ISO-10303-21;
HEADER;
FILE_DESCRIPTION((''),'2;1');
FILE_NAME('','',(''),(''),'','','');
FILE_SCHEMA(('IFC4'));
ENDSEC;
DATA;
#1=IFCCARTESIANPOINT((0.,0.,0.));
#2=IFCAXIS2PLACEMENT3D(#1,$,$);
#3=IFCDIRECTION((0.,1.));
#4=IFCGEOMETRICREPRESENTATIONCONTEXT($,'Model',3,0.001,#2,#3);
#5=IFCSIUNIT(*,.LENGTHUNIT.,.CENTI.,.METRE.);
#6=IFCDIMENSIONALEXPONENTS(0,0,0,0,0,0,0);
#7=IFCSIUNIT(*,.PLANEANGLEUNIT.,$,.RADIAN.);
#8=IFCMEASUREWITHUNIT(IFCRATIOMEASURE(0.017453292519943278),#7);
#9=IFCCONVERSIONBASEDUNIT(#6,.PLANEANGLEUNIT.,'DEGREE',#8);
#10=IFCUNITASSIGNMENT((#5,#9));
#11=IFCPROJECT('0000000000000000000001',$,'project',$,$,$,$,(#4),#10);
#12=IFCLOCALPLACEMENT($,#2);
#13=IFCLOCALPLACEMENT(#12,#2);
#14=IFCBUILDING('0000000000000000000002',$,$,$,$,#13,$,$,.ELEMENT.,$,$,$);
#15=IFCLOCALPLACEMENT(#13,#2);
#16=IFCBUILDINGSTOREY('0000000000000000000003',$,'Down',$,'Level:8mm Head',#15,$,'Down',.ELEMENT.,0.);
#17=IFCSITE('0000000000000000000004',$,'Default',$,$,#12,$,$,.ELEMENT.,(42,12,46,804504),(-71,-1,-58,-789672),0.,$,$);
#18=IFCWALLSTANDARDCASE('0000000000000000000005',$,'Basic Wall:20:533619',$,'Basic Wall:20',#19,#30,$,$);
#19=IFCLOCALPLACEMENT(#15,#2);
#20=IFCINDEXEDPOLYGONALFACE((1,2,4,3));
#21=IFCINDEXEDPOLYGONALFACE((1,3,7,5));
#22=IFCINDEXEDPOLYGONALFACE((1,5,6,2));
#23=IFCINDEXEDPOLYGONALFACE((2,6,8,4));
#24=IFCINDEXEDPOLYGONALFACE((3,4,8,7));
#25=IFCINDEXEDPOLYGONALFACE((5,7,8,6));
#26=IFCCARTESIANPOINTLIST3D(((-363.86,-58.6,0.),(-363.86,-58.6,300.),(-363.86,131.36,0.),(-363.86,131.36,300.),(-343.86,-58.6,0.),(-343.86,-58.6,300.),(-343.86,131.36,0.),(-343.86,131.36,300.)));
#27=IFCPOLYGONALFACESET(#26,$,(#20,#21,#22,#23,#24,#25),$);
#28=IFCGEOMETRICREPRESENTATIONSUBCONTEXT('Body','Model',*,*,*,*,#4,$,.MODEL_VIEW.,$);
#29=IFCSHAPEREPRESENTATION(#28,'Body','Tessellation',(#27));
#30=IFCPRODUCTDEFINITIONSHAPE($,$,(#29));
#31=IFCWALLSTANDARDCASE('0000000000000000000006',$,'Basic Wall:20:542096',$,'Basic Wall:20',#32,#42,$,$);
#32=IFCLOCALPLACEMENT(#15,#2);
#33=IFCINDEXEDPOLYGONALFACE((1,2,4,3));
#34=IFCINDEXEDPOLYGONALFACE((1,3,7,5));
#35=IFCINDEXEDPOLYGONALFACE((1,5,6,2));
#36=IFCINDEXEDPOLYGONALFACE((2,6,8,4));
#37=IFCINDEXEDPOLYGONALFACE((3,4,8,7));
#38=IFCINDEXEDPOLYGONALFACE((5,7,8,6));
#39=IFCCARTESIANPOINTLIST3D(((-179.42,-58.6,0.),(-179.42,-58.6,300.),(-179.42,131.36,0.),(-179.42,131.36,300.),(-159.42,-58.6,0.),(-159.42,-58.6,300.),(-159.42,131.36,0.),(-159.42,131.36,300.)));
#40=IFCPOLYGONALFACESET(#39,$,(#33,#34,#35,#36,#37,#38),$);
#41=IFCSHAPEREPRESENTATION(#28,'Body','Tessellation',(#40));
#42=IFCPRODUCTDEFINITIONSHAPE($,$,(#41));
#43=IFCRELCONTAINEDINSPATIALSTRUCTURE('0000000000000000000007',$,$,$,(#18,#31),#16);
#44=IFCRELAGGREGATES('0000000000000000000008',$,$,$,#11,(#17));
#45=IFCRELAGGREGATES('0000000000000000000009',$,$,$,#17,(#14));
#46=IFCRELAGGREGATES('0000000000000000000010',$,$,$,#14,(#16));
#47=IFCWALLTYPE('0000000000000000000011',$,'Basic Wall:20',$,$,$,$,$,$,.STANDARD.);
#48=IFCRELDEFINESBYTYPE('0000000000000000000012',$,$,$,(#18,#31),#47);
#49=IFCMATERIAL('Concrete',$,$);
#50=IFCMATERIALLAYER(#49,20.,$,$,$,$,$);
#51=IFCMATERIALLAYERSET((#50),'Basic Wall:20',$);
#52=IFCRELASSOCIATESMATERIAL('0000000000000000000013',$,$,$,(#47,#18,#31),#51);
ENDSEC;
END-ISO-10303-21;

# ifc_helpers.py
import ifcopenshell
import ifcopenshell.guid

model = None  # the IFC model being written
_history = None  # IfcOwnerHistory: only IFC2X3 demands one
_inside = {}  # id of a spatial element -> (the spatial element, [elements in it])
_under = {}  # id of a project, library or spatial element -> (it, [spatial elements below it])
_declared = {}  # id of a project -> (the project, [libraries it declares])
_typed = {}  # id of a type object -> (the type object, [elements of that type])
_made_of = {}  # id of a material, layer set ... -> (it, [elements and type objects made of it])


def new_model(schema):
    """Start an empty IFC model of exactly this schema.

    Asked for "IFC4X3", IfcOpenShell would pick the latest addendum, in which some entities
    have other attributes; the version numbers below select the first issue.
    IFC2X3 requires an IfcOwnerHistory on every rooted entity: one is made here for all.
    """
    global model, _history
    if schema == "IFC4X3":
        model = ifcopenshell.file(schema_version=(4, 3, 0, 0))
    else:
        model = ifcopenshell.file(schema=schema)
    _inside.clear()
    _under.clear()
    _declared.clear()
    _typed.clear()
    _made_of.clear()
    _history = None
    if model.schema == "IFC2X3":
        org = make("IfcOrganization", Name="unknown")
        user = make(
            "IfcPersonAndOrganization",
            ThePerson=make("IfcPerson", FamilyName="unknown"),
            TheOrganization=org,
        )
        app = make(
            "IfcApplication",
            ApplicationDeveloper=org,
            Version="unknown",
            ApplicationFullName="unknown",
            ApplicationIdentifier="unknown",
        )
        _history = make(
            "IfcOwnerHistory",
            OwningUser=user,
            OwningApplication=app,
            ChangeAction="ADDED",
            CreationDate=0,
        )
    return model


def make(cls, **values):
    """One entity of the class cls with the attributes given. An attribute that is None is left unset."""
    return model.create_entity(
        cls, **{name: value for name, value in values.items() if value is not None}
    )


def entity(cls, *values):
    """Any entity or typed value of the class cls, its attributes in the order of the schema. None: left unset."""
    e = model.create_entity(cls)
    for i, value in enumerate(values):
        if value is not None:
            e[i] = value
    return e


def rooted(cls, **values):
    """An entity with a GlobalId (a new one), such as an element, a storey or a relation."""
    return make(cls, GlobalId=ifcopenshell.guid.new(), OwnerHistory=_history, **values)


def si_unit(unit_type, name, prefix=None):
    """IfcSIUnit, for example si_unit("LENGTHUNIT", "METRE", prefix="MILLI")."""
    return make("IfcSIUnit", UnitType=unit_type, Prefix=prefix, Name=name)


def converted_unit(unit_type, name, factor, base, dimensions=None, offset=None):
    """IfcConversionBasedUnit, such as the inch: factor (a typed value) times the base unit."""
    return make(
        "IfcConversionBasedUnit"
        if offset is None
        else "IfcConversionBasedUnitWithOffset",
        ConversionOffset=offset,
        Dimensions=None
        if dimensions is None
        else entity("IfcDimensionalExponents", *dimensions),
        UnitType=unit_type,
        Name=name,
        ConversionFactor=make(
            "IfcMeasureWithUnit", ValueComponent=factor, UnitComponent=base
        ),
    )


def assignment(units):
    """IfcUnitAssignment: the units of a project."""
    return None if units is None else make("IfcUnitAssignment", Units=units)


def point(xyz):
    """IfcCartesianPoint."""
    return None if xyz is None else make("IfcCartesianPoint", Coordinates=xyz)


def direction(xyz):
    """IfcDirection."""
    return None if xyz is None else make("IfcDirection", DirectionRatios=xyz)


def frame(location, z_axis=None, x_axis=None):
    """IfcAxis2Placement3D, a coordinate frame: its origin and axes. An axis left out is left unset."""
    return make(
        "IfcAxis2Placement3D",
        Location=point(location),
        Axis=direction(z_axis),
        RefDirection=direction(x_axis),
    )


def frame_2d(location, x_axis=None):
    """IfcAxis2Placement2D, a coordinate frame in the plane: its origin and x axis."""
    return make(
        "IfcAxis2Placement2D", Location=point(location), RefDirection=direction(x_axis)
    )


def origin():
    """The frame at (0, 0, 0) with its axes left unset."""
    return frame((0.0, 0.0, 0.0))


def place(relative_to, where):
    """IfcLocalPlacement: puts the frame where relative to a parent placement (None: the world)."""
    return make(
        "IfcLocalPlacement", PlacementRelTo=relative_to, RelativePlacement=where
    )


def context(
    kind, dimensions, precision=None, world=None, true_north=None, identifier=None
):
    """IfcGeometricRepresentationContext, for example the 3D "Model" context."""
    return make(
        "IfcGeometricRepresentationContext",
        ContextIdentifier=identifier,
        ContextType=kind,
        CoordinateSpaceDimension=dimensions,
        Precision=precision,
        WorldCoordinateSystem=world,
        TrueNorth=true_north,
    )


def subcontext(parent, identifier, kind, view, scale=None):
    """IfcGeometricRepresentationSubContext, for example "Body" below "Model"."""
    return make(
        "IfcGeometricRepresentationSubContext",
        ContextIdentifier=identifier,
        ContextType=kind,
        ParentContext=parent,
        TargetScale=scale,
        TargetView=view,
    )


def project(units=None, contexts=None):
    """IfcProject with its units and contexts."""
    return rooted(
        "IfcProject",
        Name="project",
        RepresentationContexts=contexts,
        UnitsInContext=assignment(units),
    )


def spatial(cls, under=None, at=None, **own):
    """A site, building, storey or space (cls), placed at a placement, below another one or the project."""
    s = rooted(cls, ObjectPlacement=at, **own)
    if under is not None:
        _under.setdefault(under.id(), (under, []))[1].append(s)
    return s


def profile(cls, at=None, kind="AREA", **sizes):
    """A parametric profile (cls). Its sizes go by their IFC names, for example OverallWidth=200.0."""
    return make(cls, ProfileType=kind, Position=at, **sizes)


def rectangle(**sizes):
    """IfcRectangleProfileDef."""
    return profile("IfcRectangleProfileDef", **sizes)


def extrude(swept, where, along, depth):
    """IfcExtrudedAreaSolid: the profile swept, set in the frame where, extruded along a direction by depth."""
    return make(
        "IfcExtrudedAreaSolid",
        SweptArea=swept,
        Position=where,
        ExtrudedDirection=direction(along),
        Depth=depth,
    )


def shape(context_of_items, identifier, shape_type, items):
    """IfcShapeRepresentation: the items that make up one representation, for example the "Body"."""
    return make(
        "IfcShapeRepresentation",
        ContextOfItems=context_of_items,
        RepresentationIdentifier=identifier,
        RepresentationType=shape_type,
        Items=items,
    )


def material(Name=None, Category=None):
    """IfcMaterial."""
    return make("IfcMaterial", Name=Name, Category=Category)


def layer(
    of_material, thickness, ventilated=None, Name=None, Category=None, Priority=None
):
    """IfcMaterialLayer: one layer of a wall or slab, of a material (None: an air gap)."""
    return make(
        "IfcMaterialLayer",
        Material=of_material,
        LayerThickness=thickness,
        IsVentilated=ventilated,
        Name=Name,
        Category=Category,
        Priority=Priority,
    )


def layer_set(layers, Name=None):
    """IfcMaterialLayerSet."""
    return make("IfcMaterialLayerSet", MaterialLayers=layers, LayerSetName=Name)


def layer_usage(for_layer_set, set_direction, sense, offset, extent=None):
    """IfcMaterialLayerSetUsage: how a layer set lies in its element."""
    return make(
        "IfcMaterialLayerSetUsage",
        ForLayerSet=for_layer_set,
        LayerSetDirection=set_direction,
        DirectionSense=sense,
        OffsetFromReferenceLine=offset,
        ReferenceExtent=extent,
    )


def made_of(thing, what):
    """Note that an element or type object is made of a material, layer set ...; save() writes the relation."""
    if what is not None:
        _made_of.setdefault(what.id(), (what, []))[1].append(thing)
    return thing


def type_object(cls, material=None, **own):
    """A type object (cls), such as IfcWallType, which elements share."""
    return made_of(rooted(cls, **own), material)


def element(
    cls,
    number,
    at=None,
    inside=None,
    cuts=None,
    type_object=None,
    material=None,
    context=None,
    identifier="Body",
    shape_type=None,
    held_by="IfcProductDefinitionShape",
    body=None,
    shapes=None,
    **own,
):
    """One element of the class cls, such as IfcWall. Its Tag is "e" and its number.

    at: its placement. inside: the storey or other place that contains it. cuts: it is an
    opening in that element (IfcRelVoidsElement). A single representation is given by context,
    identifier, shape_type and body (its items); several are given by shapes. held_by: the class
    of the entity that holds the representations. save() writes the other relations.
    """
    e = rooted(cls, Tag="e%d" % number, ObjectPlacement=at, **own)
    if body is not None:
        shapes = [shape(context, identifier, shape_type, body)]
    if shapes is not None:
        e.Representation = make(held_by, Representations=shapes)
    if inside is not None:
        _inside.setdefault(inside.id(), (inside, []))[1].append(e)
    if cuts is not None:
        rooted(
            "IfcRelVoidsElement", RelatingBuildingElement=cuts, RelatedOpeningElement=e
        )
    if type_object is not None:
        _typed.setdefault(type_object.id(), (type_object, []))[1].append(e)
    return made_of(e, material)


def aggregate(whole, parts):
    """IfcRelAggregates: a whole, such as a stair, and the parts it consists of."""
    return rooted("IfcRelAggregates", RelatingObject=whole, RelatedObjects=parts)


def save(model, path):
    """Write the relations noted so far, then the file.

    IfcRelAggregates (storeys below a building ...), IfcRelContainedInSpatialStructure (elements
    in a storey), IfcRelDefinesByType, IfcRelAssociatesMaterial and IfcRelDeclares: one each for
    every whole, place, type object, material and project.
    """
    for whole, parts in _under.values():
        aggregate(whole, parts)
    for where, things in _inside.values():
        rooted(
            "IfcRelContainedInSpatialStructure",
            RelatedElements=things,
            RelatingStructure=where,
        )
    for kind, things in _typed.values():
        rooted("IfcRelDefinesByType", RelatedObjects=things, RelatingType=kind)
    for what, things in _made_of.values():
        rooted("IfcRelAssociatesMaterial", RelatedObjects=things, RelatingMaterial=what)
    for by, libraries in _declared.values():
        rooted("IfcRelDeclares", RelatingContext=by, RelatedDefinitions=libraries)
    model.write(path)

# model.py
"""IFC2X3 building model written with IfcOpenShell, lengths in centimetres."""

from ifc_helpers import new_model, entity, si_unit, converted_unit, direction, frame, frame_2d, origin, place, context, subcontext, project, spatial, rectangle, extrude, material, layer, layer_set, layer_usage, type_object, element, save


model = new_model("IFC2X3")

# Units and contexts
model_context = context("Model", 3, precision=0.001, world=origin(), true_north=direction((0.0, 1.0)))
body_context = subcontext(model_context, "Body", "Model", "MODEL_VIEW")
ifc_project = project(units=[si_unit("LENGTHUNIT", "METRE", prefix="CENTI"), converted_unit("PLANEANGLEUNIT", "DEGREE", entity("IfcRatioMeasure", 0.017453292519943278), si_unit("PLANEANGLEUNIT", "RADIAN"), dimensions=[0, 0, 0, 0, 0, 0, 0])], contexts=[model_context])

# Site, building, storey
site_placement = place(None, origin())
site = spatial("IfcSite", under=ifc_project, at=site_placement, Name="Default", CompositionType="ELEMENT", RefLatitude=(42, 12, 46, 804504), RefLongitude=(-71, -1, -58, -789672), RefElevation=0.0)
building_placement = place(site_placement, origin())
building = spatial("IfcBuilding", under=site, at=building_placement, CompositionType="ELEMENT")
storey_placement = place(building_placement, origin())
storey = spatial("IfcBuildingStorey", under=building, at=storey_placement, Name="Down", ObjectType="Level:8mm Head", LongName="Down", CompositionType="ELEMENT", Elevation=0.0)

# Shared definitions
ifc_material = material(Name="Concrete")

# Walls
ifc_layer_1 = layer(ifc_material, 20.0)
ifc_layer_set_1 = layer_set([ifc_layer_1], Name="Basic Wall:20")
wall_type_1 = type_object("IfcWallType", Name="Basic Wall:20", PredefinedType="STANDARD", material=ifc_layer_set_1)
ifc_layer_usage_1 = layer_usage(ifc_layer_set_1, "AXIS2", "POSITIVE", -10.0)
wall_1_placement = place(storey_placement, frame((-353.86, 131.36, 0.0), z_axis=(0.0, 0.0, 1.0), x_axis=(0.0, -1.0, 0.0)))
element("IfcWallStandardCase", 1, at=wall_1_placement, inside=storey, type_object=wall_type_1, material=ifc_layer_usage_1, Name="Basic Wall:20:533619", ObjectType="Basic Wall:20", context=body_context, shape_type="SweptSolid", body=[
    extrude(rectangle(XDim=189.96, YDim=20.0, at=frame_2d((94.98, 0.0), x_axis=(-1.0, 0.0))), origin(), (0.0, 0.0, 1.0), 300.0),
])
ifc_layer_usage_2 = layer_usage(ifc_layer_set_1, "AXIS2", "NEGATIVE", 10.0)
wall_2_placement = place(storey_placement, frame((-169.42, 131.36, 0.0), z_axis=(0.0, 0.0, 1.0), x_axis=(0.0, -1.0, 0.0)))
element("IfcWallStandardCase", 2, at=wall_2_placement, inside=storey, type_object=wall_type_1, material=ifc_layer_usage_2, Name="Basic Wall:20:542096", ObjectType="Basic Wall:20", context=body_context, shape_type="SweptSolid", body=[
    extrude(rectangle(XDim=189.96, YDim=20.0, at=frame_2d((94.98, 0.0), x_axis=(-1.0, 0.0))), origin(), (0.0, 0.0, 1.0), 300.0),
])

save(model, "model.ifc")
